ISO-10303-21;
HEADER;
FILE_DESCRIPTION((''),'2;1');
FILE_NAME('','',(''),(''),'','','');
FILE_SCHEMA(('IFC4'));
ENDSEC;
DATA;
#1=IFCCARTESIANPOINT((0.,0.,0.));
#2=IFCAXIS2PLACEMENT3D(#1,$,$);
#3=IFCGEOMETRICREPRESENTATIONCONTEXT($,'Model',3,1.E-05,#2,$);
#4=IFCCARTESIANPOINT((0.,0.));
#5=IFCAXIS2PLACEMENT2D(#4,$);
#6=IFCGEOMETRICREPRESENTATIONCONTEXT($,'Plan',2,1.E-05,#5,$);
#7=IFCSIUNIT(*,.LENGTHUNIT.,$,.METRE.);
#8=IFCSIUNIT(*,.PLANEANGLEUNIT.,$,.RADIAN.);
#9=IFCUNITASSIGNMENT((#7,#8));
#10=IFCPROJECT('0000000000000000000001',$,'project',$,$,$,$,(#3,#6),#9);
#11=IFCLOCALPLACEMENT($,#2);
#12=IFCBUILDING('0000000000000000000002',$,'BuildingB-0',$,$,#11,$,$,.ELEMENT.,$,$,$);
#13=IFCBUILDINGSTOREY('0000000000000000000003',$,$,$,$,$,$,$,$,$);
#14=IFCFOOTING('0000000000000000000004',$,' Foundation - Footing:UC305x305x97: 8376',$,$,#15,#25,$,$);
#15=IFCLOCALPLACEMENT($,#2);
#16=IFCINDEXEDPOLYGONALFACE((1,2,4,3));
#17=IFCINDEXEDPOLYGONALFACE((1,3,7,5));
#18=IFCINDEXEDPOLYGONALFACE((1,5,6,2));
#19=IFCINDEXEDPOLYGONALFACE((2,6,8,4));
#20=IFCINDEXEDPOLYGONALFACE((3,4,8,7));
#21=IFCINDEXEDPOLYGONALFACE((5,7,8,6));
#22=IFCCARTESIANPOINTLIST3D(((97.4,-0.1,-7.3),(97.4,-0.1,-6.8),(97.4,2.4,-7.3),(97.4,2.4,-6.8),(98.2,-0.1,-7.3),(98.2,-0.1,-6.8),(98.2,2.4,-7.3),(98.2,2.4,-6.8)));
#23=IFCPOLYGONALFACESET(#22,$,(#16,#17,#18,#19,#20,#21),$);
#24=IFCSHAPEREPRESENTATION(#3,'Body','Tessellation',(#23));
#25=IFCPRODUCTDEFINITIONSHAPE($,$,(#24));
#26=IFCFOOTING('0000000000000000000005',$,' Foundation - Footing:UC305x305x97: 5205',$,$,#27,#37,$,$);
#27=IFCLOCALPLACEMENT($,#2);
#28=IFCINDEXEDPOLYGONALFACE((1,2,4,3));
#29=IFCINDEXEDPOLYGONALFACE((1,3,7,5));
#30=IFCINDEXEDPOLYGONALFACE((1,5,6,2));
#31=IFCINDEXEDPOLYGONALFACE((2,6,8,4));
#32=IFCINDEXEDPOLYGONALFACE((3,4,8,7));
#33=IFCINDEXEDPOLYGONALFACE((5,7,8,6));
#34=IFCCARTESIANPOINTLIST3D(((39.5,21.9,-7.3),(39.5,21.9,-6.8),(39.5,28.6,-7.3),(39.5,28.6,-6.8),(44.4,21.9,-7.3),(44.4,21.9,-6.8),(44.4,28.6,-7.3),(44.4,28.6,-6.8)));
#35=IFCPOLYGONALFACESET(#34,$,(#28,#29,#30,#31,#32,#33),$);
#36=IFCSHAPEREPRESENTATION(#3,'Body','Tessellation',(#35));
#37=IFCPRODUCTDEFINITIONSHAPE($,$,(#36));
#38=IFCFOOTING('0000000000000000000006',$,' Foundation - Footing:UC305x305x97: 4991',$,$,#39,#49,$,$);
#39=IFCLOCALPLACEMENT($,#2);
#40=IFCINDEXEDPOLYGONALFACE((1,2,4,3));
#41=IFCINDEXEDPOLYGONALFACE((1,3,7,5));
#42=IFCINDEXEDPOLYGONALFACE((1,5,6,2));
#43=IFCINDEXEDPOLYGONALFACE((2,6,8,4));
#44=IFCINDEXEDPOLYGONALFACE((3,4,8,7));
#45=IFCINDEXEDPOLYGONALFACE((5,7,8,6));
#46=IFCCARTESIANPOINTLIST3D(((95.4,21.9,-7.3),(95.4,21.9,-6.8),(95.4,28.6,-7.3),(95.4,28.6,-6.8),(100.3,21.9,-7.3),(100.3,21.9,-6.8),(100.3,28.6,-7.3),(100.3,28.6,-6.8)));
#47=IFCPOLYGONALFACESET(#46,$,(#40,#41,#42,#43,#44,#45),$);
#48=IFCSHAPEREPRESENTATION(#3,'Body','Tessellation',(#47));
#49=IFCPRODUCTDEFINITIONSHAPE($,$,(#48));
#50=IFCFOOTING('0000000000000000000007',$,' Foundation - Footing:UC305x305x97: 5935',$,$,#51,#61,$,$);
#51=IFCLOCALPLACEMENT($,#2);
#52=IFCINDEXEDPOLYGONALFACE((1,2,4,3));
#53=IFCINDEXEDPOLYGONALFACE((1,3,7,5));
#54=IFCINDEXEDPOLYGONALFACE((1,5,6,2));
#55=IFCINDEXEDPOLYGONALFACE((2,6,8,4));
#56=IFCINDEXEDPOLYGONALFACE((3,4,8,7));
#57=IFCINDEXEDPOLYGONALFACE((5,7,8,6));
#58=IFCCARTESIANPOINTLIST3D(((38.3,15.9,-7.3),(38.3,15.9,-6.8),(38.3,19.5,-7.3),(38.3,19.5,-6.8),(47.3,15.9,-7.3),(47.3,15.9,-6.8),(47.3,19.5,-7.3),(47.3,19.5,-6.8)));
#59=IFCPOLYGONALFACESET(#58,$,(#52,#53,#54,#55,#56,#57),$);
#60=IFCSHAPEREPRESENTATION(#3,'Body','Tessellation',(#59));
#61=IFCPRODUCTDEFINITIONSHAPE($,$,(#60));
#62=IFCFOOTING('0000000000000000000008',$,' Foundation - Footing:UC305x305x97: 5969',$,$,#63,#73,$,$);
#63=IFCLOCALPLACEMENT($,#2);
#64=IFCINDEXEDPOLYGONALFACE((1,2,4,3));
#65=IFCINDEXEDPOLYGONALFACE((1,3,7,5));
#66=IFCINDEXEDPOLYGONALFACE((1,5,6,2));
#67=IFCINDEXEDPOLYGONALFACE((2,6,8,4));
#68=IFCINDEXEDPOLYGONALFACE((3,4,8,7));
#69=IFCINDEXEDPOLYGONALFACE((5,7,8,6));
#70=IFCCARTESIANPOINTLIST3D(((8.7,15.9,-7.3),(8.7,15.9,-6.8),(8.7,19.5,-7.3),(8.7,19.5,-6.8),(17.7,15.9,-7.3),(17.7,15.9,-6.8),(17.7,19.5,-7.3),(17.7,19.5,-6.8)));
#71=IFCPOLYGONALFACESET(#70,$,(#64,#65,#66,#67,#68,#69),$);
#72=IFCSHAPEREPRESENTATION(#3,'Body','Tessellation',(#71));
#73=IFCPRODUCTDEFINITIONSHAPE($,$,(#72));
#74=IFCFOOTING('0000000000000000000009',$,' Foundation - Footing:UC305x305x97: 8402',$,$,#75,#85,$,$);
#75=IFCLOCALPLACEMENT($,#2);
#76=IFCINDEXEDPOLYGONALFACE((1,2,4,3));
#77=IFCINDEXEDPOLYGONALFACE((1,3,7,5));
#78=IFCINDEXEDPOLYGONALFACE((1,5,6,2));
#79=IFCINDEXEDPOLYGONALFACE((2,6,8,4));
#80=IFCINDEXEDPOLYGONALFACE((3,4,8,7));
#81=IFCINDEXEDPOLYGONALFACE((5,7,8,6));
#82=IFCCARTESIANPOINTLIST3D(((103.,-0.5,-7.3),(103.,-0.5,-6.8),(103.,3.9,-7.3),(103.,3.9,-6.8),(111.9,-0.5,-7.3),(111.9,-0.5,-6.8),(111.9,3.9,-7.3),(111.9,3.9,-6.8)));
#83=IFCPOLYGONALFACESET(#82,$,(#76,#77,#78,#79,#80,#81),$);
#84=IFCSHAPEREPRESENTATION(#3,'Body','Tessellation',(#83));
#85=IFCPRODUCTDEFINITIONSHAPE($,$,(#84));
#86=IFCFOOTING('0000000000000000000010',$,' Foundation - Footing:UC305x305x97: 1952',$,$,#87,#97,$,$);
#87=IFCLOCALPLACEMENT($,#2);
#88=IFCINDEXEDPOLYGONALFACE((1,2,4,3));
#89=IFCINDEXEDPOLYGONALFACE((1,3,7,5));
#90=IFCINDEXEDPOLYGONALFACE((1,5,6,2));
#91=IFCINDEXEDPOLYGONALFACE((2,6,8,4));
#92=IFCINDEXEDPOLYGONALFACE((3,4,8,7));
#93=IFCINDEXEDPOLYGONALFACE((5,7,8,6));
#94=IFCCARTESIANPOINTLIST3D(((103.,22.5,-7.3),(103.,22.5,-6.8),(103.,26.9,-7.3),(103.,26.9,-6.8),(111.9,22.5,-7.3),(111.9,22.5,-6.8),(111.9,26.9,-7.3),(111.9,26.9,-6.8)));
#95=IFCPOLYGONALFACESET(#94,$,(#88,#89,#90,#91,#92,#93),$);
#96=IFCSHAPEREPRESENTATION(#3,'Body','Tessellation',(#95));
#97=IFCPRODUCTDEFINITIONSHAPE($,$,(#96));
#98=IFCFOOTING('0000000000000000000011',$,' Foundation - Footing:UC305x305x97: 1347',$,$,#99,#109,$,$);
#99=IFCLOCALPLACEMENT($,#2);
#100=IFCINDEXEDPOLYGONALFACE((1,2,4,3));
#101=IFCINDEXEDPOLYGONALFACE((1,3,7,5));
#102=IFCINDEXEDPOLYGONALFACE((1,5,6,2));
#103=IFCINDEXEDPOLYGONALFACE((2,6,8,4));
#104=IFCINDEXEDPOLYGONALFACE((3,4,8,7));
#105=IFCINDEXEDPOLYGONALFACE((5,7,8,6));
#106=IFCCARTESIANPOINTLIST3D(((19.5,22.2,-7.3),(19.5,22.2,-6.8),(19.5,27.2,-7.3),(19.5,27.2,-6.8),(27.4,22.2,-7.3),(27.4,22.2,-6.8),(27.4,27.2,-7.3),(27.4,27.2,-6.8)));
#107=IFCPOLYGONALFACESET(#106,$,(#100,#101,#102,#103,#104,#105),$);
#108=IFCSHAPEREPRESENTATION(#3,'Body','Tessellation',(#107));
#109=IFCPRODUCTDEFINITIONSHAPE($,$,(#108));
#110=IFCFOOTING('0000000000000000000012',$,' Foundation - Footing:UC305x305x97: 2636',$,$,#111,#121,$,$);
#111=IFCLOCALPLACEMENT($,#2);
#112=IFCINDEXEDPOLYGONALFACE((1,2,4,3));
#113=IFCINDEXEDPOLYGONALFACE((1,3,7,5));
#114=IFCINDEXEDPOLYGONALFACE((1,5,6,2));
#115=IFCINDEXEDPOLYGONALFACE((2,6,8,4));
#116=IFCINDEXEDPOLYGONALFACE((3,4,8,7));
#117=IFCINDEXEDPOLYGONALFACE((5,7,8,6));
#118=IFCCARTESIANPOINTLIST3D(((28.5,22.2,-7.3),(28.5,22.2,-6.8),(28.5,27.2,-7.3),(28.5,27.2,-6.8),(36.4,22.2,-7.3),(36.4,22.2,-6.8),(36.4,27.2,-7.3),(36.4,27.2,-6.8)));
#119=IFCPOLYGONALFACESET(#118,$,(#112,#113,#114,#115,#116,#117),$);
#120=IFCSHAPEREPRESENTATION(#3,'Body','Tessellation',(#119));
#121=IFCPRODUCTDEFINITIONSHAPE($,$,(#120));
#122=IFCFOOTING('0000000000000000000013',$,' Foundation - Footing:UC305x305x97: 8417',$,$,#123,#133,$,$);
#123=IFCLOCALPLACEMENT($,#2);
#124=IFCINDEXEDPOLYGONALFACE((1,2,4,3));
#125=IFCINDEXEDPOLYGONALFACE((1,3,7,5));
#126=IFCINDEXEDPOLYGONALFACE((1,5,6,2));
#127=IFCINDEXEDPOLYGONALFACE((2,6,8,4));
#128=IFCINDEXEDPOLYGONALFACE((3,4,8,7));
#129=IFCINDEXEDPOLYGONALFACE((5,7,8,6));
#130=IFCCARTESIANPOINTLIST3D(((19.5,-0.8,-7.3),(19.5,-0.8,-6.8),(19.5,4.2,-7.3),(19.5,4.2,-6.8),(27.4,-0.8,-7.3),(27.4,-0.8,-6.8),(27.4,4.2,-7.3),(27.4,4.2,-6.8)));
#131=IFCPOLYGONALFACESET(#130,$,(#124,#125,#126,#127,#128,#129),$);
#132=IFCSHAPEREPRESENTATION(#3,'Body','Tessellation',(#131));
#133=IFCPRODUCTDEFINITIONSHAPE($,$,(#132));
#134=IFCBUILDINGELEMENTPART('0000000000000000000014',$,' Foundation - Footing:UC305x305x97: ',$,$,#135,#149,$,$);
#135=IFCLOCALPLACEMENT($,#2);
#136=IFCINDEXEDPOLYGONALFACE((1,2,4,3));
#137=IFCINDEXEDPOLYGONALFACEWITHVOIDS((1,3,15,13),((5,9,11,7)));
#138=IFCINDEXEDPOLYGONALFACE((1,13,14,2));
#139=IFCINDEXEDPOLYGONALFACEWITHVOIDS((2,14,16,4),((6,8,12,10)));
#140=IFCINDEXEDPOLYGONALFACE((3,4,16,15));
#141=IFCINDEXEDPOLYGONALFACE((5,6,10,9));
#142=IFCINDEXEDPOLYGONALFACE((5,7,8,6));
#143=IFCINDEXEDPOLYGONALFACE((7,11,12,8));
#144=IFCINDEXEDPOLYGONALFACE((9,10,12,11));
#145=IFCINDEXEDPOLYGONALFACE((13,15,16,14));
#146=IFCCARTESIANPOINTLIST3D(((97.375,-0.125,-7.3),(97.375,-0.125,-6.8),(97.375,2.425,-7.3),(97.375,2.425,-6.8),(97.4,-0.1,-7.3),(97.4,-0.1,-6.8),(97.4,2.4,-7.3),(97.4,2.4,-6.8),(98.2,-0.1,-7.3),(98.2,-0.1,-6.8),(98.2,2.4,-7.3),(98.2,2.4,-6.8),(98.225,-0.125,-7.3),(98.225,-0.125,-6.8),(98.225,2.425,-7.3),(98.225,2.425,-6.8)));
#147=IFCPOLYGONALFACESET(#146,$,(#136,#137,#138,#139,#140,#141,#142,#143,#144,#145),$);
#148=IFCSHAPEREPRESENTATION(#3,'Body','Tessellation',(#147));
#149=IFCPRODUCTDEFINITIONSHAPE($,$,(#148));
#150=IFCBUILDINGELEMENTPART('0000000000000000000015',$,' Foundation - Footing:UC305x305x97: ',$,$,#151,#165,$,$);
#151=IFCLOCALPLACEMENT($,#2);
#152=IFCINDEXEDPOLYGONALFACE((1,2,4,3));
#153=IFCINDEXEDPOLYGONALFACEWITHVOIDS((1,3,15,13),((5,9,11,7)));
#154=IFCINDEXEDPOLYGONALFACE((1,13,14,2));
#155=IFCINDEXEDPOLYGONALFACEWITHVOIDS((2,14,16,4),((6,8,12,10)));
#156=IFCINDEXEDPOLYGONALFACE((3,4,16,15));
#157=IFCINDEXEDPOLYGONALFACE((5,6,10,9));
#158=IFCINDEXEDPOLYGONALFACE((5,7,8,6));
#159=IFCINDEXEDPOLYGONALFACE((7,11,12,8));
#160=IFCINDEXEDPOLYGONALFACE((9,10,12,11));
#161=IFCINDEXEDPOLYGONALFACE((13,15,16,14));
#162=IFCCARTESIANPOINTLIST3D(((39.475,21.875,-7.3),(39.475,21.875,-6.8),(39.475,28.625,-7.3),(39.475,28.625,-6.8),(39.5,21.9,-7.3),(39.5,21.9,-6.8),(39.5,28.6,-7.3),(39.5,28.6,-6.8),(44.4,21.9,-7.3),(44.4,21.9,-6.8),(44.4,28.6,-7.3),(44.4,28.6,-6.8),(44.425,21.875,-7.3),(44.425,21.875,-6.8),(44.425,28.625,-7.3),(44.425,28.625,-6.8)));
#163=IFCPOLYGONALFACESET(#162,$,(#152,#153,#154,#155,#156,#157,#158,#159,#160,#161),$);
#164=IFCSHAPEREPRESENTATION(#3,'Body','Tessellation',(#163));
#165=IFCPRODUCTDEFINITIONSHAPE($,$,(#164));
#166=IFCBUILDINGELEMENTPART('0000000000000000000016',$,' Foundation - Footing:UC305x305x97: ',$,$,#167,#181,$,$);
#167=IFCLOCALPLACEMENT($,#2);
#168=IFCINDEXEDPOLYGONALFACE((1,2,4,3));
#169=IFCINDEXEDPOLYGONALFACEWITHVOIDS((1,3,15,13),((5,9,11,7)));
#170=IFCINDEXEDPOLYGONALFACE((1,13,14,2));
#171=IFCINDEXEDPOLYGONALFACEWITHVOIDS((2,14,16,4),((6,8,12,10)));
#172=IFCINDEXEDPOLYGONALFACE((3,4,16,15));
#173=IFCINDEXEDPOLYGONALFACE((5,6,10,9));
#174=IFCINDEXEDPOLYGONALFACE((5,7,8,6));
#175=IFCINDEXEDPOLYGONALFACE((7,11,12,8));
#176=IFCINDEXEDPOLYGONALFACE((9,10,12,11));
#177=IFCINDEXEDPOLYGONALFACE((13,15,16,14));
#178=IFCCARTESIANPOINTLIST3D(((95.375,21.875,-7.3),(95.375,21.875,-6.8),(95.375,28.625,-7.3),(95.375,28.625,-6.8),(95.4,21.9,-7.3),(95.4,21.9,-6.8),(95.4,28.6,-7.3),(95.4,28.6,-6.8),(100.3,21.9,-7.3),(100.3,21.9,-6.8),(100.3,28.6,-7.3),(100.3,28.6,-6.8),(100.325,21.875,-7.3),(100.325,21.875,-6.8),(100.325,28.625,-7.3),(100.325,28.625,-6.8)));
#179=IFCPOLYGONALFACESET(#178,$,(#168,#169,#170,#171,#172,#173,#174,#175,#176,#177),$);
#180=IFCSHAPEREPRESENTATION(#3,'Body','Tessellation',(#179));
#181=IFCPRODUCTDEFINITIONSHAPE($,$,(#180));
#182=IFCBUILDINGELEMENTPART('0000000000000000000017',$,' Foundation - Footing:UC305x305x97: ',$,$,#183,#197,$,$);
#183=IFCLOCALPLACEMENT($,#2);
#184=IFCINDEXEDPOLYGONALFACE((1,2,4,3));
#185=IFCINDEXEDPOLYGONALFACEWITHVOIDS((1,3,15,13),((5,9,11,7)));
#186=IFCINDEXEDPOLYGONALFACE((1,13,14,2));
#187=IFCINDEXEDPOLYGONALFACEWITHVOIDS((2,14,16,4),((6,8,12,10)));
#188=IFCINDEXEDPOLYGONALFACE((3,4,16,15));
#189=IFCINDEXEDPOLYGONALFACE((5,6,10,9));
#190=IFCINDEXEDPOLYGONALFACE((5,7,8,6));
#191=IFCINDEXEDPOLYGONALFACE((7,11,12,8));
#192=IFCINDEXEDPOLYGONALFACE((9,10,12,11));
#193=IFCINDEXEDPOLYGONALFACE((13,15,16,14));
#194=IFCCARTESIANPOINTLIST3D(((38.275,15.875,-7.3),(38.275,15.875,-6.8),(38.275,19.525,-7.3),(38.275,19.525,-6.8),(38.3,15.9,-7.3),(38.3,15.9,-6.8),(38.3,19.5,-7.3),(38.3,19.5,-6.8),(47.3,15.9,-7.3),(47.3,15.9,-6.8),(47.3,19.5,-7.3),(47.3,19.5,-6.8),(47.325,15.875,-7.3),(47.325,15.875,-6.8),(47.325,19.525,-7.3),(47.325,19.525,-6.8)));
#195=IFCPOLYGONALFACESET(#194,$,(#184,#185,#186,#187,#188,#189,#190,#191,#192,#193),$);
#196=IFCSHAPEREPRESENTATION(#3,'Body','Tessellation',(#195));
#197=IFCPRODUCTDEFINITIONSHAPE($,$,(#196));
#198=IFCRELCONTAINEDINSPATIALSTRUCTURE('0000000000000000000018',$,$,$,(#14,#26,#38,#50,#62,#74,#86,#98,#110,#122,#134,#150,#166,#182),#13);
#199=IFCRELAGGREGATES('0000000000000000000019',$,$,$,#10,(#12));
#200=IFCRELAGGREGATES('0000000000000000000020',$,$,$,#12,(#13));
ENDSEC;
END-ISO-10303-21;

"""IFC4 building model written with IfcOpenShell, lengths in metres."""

from ifc_helpers import new_model, si_unit, origin, origin_2d, place, context, project, spatial, polyline, outline, extrude, element, save


model = new_model("IFC4")

# Units and contexts
model_context = context("Model", 3, precision=1e-05, world=origin())
plan_context = context("Plan", 2, precision=1e-05, world=origin_2d())
ifc_project = project(units=[si_unit("LENGTHUNIT", "METRE"), si_unit("PLANEANGLEUNIT", "RADIAN")], contexts=[model_context, plan_context])

# Building, storey
building_placement = place(None, origin())
building = spatial("IfcBuilding", under=ifc_project, at=building_placement, Name="BuildingB-0", CompositionType="ELEMENT")
storey = spatial("IfcBuildingStorey", under=building)

# Footings
element("IfcFooting", 1, inside=storey, Name=" Foundation - Footing:UC305x305x97: 8376", context=model_context, shape_type="SweptSolid", body=[
    extrude(outline(polyline([(97.4, 2.4, -7.3), (98.2, 2.4, -7.3), (98.2, -0.1, -7.3), (97.4, -0.1, -7.3), (97.4, 2.4, -7.3)])), None, (0.0, 0.0, 1.0), 0.5),
])
element("IfcFooting", 2, inside=storey, Name=" Foundation - Footing:UC305x305x97: 5205", context=model_context, shape_type="SweptSolid", body=[
    extrude(outline(polyline([(44.4, 21.9, -7.3), (44.4, 28.6, -7.3), (39.5, 28.6, -7.3), (39.5, 21.9, -7.3), (44.4, 21.9, -7.3)])), None, (0.0, 0.0, 1.0), 0.5),
])
element("IfcFooting", 3, inside=storey, Name=" Foundation - Footing:UC305x305x97: 4991", context=model_context, shape_type="SweptSolid", body=[
    extrude(outline(polyline([(95.4, 21.9, -7.3), (95.4, 28.6, -7.3), (100.3, 28.6, -7.3), (100.3, 21.9, -7.3), (95.4, 21.9, -7.3)])), None, (0.0, 0.0, 1.0), 0.5),
])
element("IfcFooting", 4, inside=storey, Name=" Foundation - Footing:UC305x305x97: 5935", context=model_context, shape_type="SweptSolid", body=[
    extrude(outline(polyline([(47.3, 19.5, -7.3), (38.3, 19.5, -7.3), (38.3, 15.9, -7.3), (47.3, 15.9, -7.3), (47.3, 19.5, -7.3)])), None, (0.0, 0.0, 1.0), 0.5),
])
element("IfcFooting", 5, inside=storey, Name=" Foundation - Footing:UC305x305x97: 5969", context=model_context, shape_type="SweptSolid", body=[
    extrude(outline(polyline([(17.7, 19.5, -7.3), (8.7, 19.5, -7.3), (8.7, 15.9, -7.3), (17.7, 15.9, -7.3), (17.7, 19.5, -7.3)])), None, (0.0, 0.0, 1.0), 0.5),
])
element("IfcFooting", 6, inside=storey, Name=" Foundation - Footing:UC305x305x97: 8402", context=model_context, shape_type="SweptSolid", body=[
    extrude(outline(polyline([(111.9, 3.9, -7.3), (103.0, 3.9, -7.3), (103.0, -0.5, -7.3), (111.9, -0.5, -7.3), (111.9, 3.9, -7.3)])), None, (0.0, 0.0, 1.0), 0.5),
])
element("IfcFooting", 7, inside=storey, Name=" Foundation - Footing:UC305x305x97: 1952", context=model_context, shape_type="SweptSolid", body=[
    extrude(outline(polyline([(111.9, 26.9, -7.3), (103.0, 26.9, -7.3), (103.0, 22.5, -7.3), (111.9, 22.5, -7.3), (111.9, 26.9, -7.3)])), None, (0.0, 0.0, 1.0), 0.5),
])
element("IfcFooting", 8, inside=storey, Name=" Foundation - Footing:UC305x305x97: 1347", context=model_context, shape_type="SweptSolid", body=[
    extrude(outline(polyline([(27.4, 27.2, -7.3), (19.5, 27.2, -7.3), (19.5, 22.2, -7.3), (27.4, 22.2, -7.3), (27.4, 27.2, -7.3)])), None, (0.0, 0.0, 1.0), 0.5),
])
element("IfcFooting", 9, inside=storey, Name=" Foundation - Footing:UC305x305x97: 2636", context=model_context, shape_type="SweptSolid", body=[
    extrude(outline(polyline([(36.4, 27.2, -7.3), (28.5, 27.2, -7.3), (28.5, 22.2, -7.3), (36.4, 22.2, -7.3), (36.4, 27.2, -7.3)])), None, (0.0, 0.0, 1.0), 0.5),
])
element("IfcFooting", 10, inside=storey, Name=" Foundation - Footing:UC305x305x97: 8417", context=model_context, shape_type="SweptSolid", body=[
    extrude(outline(polyline([(27.4, 4.2, -7.3), (19.5, 4.2, -7.3), (19.5, -0.8, -7.3), (27.4, -0.8, -7.3), (27.4, 4.2, -7.3)])), None, (0.0, 0.0, 1.0), 0.5),
])

# Building element parts, openings
building_element_part_1 = element("IfcBuildingElementPart", 11, inside=storey, Name=" Foundation - Footing:UC305x305x97: ", context=model_context, shape_type="SweptSolid", body=[
    extrude(outline(polyline([(97.375, 2.425, -7.3), (98.225, 2.425, -7.3), (98.225, -0.125, -7.3), (97.375, -0.125, -7.3), (97.375, 2.425, -7.3)])), None, (0.0, 0.0, 1.0), 0.5),
])
element("IfcOpeningElement", 12, inside=storey, cuts=building_element_part_1, context=model_context, shape_type="SweptSolid", body=[
    extrude(outline(polyline([(97.4, 2.4, -7.3), (98.2, 2.4, -7.3), (98.2, -0.1, -7.3), (97.4, -0.1, -7.3), (97.4, 2.4, -7.3)])), None, (0.0, 0.0, 1.0), 0.5),
])
building_element_part_2 = element("IfcBuildingElementPart", 13, inside=storey, Name=" Foundation - Footing:UC305x305x97: ", context=model_context, shape_type="SweptSolid", body=[
    extrude(outline(polyline([(44.425, 21.875, -7.3), (44.425, 28.625, -7.3), (39.475, 28.625, -7.3), (39.475, 21.875, -7.3), (44.425, 21.875, -7.3)])), None, (0.0, 0.0, 1.0), 0.5),
])
element("IfcOpeningElement", 14, inside=storey, cuts=building_element_part_2, context=model_context, shape_type="SweptSolid", body=[
    extrude(outline(polyline([(44.4, 21.9, -7.3), (44.4, 28.6, -7.3), (39.5, 28.6, -7.3), (39.5, 21.9, -7.3), (44.4, 21.9, -7.3)])), None, (0.0, 0.0, 1.0), 0.5),
])
building_element_part_3 = element("IfcBuildingElementPart", 15, inside=storey, Name=" Foundation - Footing:UC305x305x97: ", context=model_context, shape_type="SweptSolid", body=[
    extrude(outline(polyline([(95.375, 21.875, -7.3), (95.375, 28.625, -7.3), (100.325, 28.625, -7.3), (100.325, 21.875, -7.3), (95.375, 21.875, -7.3)])), None, (0.0, 0.0, 1.0), 0.5),
])
element("IfcOpeningElement", 16, inside=storey, cuts=building_element_part_3, context=model_context, shape_type="SweptSolid", body=[
    extrude(outline(polyline([(95.4, 21.9, -7.3), (95.4, 28.6, -7.3), (100.3, 28.6, -7.3), (100.3, 21.9, -7.3), (95.4, 21.9, -7.3)])), None, (0.0, 0.0, 1.0), 0.5),
])
building_element_part_4 = element("IfcBuildingElementPart", 17, inside=storey, Name=" Foundation - Footing:UC305x305x97: ", context=model_context, shape_type="SweptSolid", body=[
    extrude(outline(polyline([(47.325, 19.525, -7.3), (38.275, 19.525, -7.3), (38.275, 15.875, -7.3), (47.325, 15.875, -7.3), (47.325, 19.525, -7.3)])), None, (0.0, 0.0, 1.0), 0.5),
])
element("IfcOpeningElement", 18, inside=storey, cuts=building_element_part_4, context=model_context, shape_type="SweptSolid", body=[
    extrude(outline(polyline([(47.3, 19.5, -7.3), (38.3, 19.5, -7.3), (38.3, 15.9, -7.3), (47.3, 15.9, -7.3), (47.3, 19.5, -7.3)])), None, (0.0, 0.0, 1.0), 0.5),
])

save(model, "model.ifc")
